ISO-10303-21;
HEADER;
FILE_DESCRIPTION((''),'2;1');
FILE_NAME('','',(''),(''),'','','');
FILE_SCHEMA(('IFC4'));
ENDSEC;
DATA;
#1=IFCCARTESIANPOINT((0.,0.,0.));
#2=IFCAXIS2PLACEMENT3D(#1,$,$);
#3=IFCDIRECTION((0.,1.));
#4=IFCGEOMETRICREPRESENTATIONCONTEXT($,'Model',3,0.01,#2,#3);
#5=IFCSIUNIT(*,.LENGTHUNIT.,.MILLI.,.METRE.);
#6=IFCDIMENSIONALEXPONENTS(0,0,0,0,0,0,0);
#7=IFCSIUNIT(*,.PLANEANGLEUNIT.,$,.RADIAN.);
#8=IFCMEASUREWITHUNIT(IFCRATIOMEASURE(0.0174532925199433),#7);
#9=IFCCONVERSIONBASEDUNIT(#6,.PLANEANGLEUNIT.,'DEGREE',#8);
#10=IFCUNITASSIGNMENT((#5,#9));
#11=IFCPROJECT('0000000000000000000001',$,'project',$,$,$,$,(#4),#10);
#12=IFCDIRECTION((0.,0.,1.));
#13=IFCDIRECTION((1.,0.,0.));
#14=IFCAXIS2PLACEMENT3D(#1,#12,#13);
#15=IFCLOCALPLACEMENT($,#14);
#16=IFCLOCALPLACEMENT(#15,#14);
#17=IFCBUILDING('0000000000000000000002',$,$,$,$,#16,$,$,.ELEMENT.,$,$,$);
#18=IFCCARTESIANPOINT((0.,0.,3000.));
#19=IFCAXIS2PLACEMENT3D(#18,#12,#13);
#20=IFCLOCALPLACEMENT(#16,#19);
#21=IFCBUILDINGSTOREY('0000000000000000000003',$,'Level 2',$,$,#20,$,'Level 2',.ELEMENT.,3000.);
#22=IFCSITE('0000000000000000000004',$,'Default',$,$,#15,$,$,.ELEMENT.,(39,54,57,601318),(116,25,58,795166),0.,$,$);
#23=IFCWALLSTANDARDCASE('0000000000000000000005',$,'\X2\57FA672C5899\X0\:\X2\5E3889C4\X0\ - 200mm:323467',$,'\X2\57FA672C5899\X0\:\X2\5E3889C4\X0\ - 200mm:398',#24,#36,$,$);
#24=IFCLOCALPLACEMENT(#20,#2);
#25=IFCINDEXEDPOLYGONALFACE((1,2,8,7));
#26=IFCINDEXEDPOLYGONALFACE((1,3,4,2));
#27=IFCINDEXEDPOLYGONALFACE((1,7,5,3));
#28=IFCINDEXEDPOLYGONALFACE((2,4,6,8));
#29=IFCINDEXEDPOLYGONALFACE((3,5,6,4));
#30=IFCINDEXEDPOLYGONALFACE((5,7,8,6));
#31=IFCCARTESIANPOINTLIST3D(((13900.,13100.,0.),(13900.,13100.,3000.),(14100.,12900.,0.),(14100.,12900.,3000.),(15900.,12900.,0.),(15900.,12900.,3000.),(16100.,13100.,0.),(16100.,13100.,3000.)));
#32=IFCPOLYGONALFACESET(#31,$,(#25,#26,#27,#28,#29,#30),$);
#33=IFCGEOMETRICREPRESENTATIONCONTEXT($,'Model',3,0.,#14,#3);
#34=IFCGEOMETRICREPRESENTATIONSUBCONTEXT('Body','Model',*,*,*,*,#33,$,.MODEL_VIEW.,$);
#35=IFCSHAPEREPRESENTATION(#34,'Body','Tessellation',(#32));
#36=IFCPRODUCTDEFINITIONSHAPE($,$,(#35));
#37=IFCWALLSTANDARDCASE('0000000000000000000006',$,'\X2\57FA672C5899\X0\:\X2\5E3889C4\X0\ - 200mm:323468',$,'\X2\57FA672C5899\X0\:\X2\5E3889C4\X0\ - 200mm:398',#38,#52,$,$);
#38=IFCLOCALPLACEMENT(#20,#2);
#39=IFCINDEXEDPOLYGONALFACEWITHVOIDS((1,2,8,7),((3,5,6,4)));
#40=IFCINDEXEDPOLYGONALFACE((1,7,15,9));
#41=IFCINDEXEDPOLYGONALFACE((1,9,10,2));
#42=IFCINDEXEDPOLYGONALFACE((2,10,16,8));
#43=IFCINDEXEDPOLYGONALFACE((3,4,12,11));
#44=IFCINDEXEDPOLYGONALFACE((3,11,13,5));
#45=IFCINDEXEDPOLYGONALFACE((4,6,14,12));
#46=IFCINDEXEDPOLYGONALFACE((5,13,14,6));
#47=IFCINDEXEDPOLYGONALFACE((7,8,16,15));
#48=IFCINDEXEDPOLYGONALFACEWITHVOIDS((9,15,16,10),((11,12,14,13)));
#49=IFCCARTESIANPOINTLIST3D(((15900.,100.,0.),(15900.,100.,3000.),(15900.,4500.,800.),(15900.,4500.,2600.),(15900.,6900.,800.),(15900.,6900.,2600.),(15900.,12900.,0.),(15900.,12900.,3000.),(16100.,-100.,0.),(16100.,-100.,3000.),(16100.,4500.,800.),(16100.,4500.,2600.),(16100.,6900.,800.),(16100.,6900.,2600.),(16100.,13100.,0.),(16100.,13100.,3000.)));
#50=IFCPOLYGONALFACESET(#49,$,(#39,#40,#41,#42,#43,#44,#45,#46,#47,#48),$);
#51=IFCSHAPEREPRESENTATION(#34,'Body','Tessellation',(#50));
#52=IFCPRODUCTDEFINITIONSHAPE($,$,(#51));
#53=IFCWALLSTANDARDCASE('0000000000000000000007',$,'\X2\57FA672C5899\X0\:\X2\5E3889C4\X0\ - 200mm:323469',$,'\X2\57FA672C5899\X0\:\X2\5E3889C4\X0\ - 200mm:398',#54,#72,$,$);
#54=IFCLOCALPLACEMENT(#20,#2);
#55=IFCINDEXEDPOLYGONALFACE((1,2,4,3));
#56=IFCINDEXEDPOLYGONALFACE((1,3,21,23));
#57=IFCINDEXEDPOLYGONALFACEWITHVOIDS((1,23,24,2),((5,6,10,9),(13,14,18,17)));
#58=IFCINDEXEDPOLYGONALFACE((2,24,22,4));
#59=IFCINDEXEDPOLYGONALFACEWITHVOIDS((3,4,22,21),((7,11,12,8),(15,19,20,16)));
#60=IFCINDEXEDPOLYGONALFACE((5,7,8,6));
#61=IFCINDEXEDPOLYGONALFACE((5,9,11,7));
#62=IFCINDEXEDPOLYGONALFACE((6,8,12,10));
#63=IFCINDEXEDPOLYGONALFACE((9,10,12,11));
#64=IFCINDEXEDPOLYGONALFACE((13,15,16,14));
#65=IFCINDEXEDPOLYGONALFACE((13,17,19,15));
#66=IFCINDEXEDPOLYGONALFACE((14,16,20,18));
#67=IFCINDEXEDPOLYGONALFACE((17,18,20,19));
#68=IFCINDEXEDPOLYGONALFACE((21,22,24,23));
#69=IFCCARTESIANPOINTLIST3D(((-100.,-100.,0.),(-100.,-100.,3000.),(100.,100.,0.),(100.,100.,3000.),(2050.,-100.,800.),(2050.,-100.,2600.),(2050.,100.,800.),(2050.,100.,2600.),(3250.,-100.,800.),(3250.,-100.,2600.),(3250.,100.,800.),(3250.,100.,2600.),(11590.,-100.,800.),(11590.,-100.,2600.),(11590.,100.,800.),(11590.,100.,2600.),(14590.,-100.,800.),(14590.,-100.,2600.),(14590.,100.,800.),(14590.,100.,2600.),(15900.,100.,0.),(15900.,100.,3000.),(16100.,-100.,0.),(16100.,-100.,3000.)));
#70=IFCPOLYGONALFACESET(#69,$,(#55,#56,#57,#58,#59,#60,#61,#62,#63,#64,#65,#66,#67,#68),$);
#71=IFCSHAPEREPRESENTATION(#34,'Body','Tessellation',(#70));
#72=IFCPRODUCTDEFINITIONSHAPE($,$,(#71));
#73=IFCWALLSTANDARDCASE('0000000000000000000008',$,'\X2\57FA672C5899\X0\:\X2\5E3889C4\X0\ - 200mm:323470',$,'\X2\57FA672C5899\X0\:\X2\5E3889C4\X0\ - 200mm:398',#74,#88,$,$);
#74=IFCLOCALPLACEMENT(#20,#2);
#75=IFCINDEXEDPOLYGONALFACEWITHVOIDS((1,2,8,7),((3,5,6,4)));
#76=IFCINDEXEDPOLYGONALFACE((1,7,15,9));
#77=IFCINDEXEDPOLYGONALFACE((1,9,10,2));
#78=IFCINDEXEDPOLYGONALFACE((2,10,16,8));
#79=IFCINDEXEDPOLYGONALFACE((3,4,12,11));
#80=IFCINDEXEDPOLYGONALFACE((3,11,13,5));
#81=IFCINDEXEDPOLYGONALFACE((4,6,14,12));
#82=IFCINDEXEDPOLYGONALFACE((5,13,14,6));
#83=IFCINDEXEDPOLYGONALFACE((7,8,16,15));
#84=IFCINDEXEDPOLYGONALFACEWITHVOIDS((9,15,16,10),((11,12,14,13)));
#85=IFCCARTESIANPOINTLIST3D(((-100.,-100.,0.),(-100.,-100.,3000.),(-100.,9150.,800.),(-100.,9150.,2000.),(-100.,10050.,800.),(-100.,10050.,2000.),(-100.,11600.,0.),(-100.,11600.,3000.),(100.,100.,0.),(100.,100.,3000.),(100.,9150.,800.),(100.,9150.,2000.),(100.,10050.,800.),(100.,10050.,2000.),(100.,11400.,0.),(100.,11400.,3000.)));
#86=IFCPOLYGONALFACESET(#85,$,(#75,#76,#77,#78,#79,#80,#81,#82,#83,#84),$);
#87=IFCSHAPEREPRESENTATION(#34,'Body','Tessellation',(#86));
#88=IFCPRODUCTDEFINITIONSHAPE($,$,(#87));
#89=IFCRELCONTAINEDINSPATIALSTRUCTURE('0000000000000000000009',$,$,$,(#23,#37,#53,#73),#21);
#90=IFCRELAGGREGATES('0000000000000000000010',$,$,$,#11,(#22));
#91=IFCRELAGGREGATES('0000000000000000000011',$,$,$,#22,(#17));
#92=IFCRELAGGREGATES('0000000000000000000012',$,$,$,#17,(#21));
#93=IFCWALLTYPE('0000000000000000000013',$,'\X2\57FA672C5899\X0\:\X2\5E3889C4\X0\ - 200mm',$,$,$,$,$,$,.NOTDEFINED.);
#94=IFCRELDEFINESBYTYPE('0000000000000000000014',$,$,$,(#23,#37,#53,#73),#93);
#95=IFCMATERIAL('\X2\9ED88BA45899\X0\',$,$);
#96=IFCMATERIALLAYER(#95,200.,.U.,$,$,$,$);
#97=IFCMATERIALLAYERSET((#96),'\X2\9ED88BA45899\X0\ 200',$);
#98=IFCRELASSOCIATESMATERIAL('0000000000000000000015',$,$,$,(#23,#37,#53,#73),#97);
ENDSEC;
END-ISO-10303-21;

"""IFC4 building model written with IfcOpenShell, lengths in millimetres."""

from ifc_helpers import new_model, entity, si_unit, converted_unit, direction, frame, origin, origin_with_axes, place, context, subcontext, project, spatial, polyline, outline, extrude, material, layer, layer_set, layer_usage, type_object, element, save


model = new_model("IFC4")

# Units and contexts
model_context_1 = context("Model", 3, precision=0.01, world=origin(), true_north=direction((0.0, 1.0)))
model_context_2 = context("Model", 3, precision=0.0, world=origin_with_axes(), true_north=direction((0.0, 1.0)))
body_context = subcontext(model_context_2, "Body", "Model", "MODEL_VIEW")
ifc_project = project(units=[si_unit("LENGTHUNIT", "METRE", prefix="MILLI"), converted_unit("PLANEANGLEUNIT", "DEGREE", entity("IfcRatioMeasure", 0.0174532925199433), si_unit("PLANEANGLEUNIT", "RADIAN"), dimensions=[0, 0, 0, 0, 0, 0, 0])], contexts=[model_context_1])

# Site, building, storey
site_placement = place(None, origin_with_axes())
site = spatial("IfcSite", under=ifc_project, at=site_placement, Name="Default", CompositionType="ELEMENT", RefLatitude=(39, 54, 57, 601318), RefLongitude=(116, 25, 58, 795166), RefElevation=0.0)
building_placement = place(site_placement, origin_with_axes())
building = spatial("IfcBuilding", under=site, at=building_placement, CompositionType="ELEMENT")
storey_placement = place(building_placement, frame((0.0, 0.0, 3000.0), z_axis=(0.0, 0.0, 1.0), x_axis=(1.0, 0.0, 0.0)))
storey = spatial("IfcBuildingStorey", under=building, at=storey_placement, Name="Level 2", LongName="Level 2", CompositionType="ELEMENT", Elevation=3000.0)

# Shared definitions
ifc_material_1 = material(Name="默认墙")
ifc_layer_1 = layer(ifc_material_1, 200.0, ventilated="UNKNOWN")
ifc_layer_set_1 = layer_set([ifc_layer_1], Name="默认墙 200")
wall_type = type_object("IfcWallType", Name="基本墙:常规 - 200mm", PredefinedType="NOTDEFINED")

# Wall
ifc_layer_usage_1 = layer_usage(ifc_layer_set_1, "AXIS2", "POSITIVE", -100.0)
wall_1_placement = place(storey_placement, frame((14000.0, 13000.0, 0.0), z_axis=(0.0, 0.0, 1.0), x_axis=(1.0, 0.0, 0.0)))
element("IfcWallStandardCase", 1, at=wall_1_placement, inside=storey, type_object=wall_type, material=ifc_layer_usage_1, Name="基本墙:常规 - 200mm:323467", ObjectType="基本墙:常规 - 200mm:398", context=body_context, shape_type="SweptSolid", body=[
    extrude(outline(polyline([(100.0, -100.0), (1900.0, -100.0), (2100.0, 100.0), (-100.0, 100.0), (100.0, -100.0)])), origin_with_axes(), (0.0, 0.0, 1.0), 3000.0),
])

# Wall, opening
ifc_layer_usage_2 = layer_usage(ifc_layer_set_1, "AXIS2", "POSITIVE", -100.0)
wall_2_placement = place(storey_placement, frame((16000.0, 13000.0, 0.0), z_axis=(0.0, 0.0, 1.0), x_axis=(0.0, -1.0, 0.0)))
wall_2 = element("IfcWallStandardCase", 2, at=wall_2_placement, inside=storey, type_object=wall_type, material=ifc_layer_usage_2, Name="基本墙:常规 - 200mm:323468", ObjectType="基本墙:常规 - 200mm:398", context=body_context, shape_type="SweptSolid", body=[
    extrude(outline(polyline([(100.0, -100.0), (12900.0, -100.0), (13100.0, 100.0), (-100.0, 100.0), (100.0, -100.0)])), origin_with_axes(), (0.0, 0.0, 1.0), 3000.0),
])
opening_1_placement = place(wall_2_placement, frame((7300.0, 0.0, 800.0), z_axis=(0.0, 0.0, 1.0), x_axis=(1.0, 0.0, 0.0)))
element("IfcOpeningElement", 3, at=opening_1_placement, cuts=wall_2, context=body_context, shape_type="SweptSolid", body=[
    extrude(outline(polyline([(-1200.0, 0.0), (-1200.0, -1800.0), (1200.0, -1800.0), (1200.0, 0.0), (-1200.0, 0.0)])), frame((0.0, -100.0, 0.0), z_axis=(0.0, 1.0, 0.0), x_axis=(1.0, 0.0, 0.0)), (0.0, 0.0, 1.0), 200.0),
])

# Wall, openings
ifc_layer_usage_3 = layer_usage(ifc_layer_set_1, "AXIS2", "POSITIVE", -100.0)
wall_3_placement = place(storey_placement, frame((16000.0, 0.0, 0.0), z_axis=(0.0, 0.0, 1.0), x_axis=(-1.0, 0.0, 0.0)))
wall_3 = element("IfcWallStandardCase", 4, at=wall_3_placement, inside=storey, type_object=wall_type, material=ifc_layer_usage_3, Name="基本墙:常规 - 200mm:323469", ObjectType="基本墙:常规 - 200mm:398", context=body_context, shape_type="SweptSolid", body=[
    extrude(outline(polyline([(100.0, -100.0), (15900.0, -100.0), (16100.0, 100.0), (-100.0, 100.0), (100.0, -100.0)])), origin_with_axes(), (0.0, 0.0, 1.0), 3000.0),
])
opening_2_placement = place(wall_3_placement, frame((13350.0, 0.0, 800.0), z_axis=(0.0, 0.0, 1.0), x_axis=(1.0, 0.0, 0.0)))
element("IfcOpeningElement", 5, at=opening_2_placement, cuts=wall_3, context=body_context, shape_type="SweptSolid", body=[
    extrude(outline(polyline([(-600.0, 0.0), (-600.0, -1800.0), (600.0, -1800.0), (600.0, 0.0), (-600.0, 0.0)])), frame((0.0, -100.0, 0.0), z_axis=(0.0, 1.0, 0.0), x_axis=(1.0, 0.0, 0.0)), (0.0, 0.0, 1.0), 200.0),
])
opening_3_placement = place(wall_3_placement, frame((2910.0, 0.0, 800.0), z_axis=(0.0, 0.0, 1.0), x_axis=(1.0, 0.0, 0.0)))
element("IfcOpeningElement", 6, at=opening_3_placement, cuts=wall_3, context=body_context, shape_type="SweptSolid", body=[
    extrude(outline(polyline([(-1500.0, 0.0), (-1500.0, -1800.0), (1500.0, -1800.0), (1500.0, 0.0), (-1500.0, 0.0)])), frame((0.0, -100.0, 0.0), z_axis=(0.0, 1.0, 0.0), x_axis=(1.0, 0.0, 0.0)), (0.0, 0.0, 1.0), 200.0),
])

# Wall, opening
ifc_layer_usage_4 = layer_usage(ifc_layer_set_1, "AXIS2", "POSITIVE", -100.0)
wall_4_placement = place(storey_placement, frame((0.0, 0.0, 0.0), z_axis=(0.0, 0.0, 1.0), x_axis=(0.0, 1.0, 0.0)))
wall_4 = element("IfcWallStandardCase", 7, at=wall_4_placement, inside=storey, type_object=wall_type, material=ifc_layer_usage_4, Name="基本墙:常规 - 200mm:323470", ObjectType="基本墙:常规 - 200mm:398", context=body_context, shape_type="SweptSolid", body=[
    extrude(outline(polyline([(100.0, -100.0), (11400.0, -100.0), (11600.0, 100.0), (-100.0, 100.0), (100.0, -100.0)])), origin_with_axes(), (0.0, 0.0, 1.0), 3000.0),
])
opening_4_placement = place(wall_4_placement, frame((9600.0, 0.0, 800.0), z_axis=(0.0, 0.0, 1.0), x_axis=(1.0, 0.0, 0.0)))
element("IfcOpeningElement", 8, at=opening_4_placement, cuts=wall_4, context=body_context, shape_type="SweptSolid", body=[
    extrude(outline(polyline([(450.0, -1200.0), (450.0, 0.0), (-450.0, 0.0), (-450.0, -1200.0), (450.0, -1200.0)])), frame((0.0, 100.0, 0.0), z_axis=(0.0, -1.0, 0.0), x_axis=(-1.0, 0.0, 0.0)), (0.0, 0.0, 1.0), 200.0),
])

save(model, "model.ifc")
